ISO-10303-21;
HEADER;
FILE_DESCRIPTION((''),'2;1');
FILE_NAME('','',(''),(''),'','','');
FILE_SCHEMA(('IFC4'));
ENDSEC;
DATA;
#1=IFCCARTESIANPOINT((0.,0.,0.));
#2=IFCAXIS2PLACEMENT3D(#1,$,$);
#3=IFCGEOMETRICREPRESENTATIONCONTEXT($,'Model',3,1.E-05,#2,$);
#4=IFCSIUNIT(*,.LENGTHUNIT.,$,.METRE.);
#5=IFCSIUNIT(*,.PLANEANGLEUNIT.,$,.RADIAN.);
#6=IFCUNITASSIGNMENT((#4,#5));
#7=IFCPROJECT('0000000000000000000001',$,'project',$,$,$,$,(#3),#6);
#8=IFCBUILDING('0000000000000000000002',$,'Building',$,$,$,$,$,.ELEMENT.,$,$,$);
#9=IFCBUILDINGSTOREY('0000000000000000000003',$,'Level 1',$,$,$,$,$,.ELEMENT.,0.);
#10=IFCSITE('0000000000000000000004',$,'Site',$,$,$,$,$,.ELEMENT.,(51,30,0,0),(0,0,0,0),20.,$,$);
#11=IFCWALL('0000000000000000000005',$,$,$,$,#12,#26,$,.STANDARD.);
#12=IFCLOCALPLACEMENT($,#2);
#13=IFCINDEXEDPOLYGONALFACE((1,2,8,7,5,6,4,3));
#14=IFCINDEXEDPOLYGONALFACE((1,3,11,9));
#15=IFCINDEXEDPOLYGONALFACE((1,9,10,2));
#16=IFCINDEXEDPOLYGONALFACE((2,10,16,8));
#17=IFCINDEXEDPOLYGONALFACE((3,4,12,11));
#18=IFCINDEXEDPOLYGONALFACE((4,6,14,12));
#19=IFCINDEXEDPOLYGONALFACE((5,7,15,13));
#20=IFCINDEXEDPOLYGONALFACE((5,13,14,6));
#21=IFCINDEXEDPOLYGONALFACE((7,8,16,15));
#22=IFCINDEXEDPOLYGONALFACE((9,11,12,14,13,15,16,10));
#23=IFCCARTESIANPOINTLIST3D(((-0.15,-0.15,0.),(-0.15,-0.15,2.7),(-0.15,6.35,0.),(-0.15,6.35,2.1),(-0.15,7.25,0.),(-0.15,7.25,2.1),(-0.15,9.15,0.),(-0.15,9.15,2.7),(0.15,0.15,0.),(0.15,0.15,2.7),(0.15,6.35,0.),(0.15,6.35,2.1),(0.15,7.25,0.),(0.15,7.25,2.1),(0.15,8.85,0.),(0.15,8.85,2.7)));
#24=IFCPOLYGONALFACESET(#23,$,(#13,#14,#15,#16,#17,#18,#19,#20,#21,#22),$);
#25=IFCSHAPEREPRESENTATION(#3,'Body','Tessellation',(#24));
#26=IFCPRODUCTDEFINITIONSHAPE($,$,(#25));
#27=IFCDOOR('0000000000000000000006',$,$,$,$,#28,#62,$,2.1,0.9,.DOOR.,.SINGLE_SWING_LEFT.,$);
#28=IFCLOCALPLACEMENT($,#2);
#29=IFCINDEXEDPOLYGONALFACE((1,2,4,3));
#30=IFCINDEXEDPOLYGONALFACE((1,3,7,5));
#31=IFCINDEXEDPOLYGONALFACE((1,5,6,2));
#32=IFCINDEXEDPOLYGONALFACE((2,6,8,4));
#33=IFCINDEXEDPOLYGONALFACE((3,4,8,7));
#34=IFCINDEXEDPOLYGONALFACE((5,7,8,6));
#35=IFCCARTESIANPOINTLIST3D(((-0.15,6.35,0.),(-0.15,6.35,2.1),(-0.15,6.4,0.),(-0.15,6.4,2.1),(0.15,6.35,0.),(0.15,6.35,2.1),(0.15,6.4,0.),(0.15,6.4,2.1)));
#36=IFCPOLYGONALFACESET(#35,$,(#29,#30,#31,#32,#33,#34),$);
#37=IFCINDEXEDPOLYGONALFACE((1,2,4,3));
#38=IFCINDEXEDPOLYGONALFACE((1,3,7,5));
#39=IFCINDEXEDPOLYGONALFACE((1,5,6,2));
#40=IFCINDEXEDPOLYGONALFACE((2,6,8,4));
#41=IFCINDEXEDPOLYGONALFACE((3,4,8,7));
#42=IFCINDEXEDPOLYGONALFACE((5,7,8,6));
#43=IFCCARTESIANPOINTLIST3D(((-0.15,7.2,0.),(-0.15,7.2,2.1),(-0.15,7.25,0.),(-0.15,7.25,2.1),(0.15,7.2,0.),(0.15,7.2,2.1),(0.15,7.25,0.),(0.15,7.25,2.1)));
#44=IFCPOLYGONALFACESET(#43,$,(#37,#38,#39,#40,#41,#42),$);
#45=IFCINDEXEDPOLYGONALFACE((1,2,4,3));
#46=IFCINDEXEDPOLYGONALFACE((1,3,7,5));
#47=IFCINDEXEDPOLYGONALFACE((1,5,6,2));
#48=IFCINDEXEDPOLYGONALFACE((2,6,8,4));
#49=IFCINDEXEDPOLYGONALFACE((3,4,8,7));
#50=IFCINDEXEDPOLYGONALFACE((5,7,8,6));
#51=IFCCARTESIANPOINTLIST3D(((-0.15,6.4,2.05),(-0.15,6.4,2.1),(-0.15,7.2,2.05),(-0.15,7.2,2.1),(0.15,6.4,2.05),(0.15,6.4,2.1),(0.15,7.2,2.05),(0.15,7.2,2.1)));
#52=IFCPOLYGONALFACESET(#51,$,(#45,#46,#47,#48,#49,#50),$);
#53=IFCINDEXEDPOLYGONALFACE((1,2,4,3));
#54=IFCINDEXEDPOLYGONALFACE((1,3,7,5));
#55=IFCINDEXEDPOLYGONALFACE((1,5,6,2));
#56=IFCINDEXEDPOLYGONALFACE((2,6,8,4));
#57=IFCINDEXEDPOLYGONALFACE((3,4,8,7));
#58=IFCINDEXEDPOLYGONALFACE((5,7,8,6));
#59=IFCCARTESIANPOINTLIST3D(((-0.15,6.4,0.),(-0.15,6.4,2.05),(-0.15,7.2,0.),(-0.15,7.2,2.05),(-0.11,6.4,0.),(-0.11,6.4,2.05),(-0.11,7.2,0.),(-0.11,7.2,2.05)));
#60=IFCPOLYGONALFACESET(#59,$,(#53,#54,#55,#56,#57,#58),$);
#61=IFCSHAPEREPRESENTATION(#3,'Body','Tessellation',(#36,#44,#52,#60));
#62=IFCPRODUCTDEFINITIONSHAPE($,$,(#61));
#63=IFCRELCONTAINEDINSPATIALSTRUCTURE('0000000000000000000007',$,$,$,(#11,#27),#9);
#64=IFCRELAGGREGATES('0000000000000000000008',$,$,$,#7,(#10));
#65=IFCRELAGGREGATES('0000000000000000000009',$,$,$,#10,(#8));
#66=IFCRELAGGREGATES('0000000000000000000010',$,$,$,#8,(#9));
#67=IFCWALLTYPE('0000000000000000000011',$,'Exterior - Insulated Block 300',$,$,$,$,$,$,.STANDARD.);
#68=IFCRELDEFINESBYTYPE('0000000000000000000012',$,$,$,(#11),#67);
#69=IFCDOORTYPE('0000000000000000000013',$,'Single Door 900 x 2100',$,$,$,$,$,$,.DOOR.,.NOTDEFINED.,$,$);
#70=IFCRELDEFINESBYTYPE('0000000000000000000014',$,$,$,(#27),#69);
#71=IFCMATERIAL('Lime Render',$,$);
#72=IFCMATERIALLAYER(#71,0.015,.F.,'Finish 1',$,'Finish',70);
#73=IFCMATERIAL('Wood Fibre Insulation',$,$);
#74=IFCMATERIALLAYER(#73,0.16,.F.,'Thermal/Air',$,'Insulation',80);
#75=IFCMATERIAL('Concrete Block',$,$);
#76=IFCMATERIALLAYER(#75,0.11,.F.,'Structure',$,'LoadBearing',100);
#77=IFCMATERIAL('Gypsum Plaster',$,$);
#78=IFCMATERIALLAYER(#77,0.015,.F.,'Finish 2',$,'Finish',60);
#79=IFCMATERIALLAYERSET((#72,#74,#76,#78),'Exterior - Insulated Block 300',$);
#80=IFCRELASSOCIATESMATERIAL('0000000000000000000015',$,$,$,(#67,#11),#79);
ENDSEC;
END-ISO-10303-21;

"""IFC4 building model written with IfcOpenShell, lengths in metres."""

from ifc_helpers import new_model, si_unit, frame, frame_2d, origin, origin_with_axes, origin_2d, place, context, project, spatial, polyline, rectangle, outline, extrude, material, layer, layer_set, layer_usage, type_object, element, fill, save


model = new_model("IFC4")

# Units and contexts
model_context = context("Model", 3, precision=1e-05, world=origin())
ifc_project = project(units=[si_unit("LENGTHUNIT", "METRE"), si_unit("PLANEANGLEUNIT", "RADIAN")], contexts=[model_context])

# Site, building, storey
site = spatial("IfcSite", under=ifc_project, Name="Site", CompositionType="ELEMENT", RefLatitude=(51, 30, 0, 0), RefLongitude=(0, 0, 0, 0), RefElevation=20.0)
building = spatial("IfcBuilding", under=site, Name="Building", CompositionType="ELEMENT")
storey = spatial("IfcBuildingStorey", under=building, Name="Level 1", CompositionType="ELEMENT", Elevation=0.0)

# Shared definitions
ifc_material_1 = material(Name="Lime Render")
ifc_layer_1 = layer(ifc_material_1, 0.015, ventilated=False, Name="Finish 1", Category="Finish", Priority=70)
ifc_material_2 = material(Name="Wood Fibre Insulation")
ifc_layer_2 = layer(ifc_material_2, 0.16, ventilated=False, Name="Thermal/Air", Category="Insulation", Priority=80)
ifc_material_3 = material(Name="Concrete Block")
ifc_layer_3 = layer(ifc_material_3, 0.11, ventilated=False, Name="Structure", Category="LoadBearing", Priority=100)
ifc_material_4 = material(Name="Gypsum Plaster")
ifc_layer_4 = layer(ifc_material_4, 0.015, ventilated=False, Name="Finish 2", Category="Finish", Priority=60)
ifc_layer_set = layer_set([ifc_layer_1, ifc_layer_2, ifc_layer_3, ifc_layer_4], Name="Exterior - Insulated Block 300")
ifc_layer_usage = layer_usage(ifc_layer_set, "AXIS2", "POSITIVE", -0.15)
wall_type_1 = type_object("IfcWallType", Name="Exterior - Insulated Block 300", PredefinedType="STANDARD", material=ifc_layer_set)

# Wall, opening, door
wall_1_placement = place(None, frame((0.0, 0.0, 0.0), z_axis=(0.0, 0.0, 1.0), x_axis=(0.0, 1.0, 0.0)))
wall_1 = element("IfcWall", 1, at=wall_1_placement, inside=storey, type_object=wall_type_1, material=ifc_layer_usage, PredefinedType="STANDARD", context=model_context, shape_type="SweptSolid", body=[
    extrude(outline(polyline([(0.15, -0.15), (8.85, -0.15), (9.15, 0.15), (-0.15, 0.15), (0.15, -0.15)])), origin(), (0.0, 0.0, 1.0), 2.7),
])
opening_1_placement = place(wall_1_placement, frame((6.8, 0.0, 0.0), z_axis=(0.0, 0.0, 1.0), x_axis=(1.0, 0.0, 0.0)))
opening_1 = element("IfcOpeningElement", 2, at=opening_1_placement, cuts=wall_1, PredefinedType="OPENING", context=model_context, shape_type="SweptSolid", body=[
    extrude(rectangle(XDim=0.9, YDim=0.302, at=origin_2d()), origin(), (0.0, 0.0, 1.0), 2.1),
])
door_type = type_object("IfcDoorType", Name="Single Door 900 x 2100", OperationType="NOTDEFINED", PredefinedType="DOOR")
door_placement = place(opening_1_placement, origin_with_axes())
door = element("IfcDoor", 3, at=door_placement, inside=storey, type_object=door_type, OperationType="SINGLE_SWING_LEFT", OverallHeight=2.1, OverallWidth=0.9, PredefinedType="DOOR", context=model_context, shape_type="SweptSolid", body=[
    extrude(rectangle(XDim=0.05, YDim=0.3, at=frame_2d((-0.425, 0.0))), origin(), (0.0, 0.0, 1.0), 2.1),
    extrude(rectangle(XDim=0.05, YDim=0.3, at=frame_2d((0.425, 0.0))), origin(), (0.0, 0.0, 1.0), 2.1),
    extrude(rectangle(XDim=0.8, YDim=0.3, at=origin_2d()), frame((0.0, 0.0, 2.05)), (0.0, 0.0, 1.0), 0.05),
    extrude(rectangle(XDim=0.8, YDim=0.04, at=frame_2d((0.0, 0.13))), origin(), (0.0, 0.0, 1.0), 2.05),
])
fill(opening_1, door)

save(model, "model.ifc")
